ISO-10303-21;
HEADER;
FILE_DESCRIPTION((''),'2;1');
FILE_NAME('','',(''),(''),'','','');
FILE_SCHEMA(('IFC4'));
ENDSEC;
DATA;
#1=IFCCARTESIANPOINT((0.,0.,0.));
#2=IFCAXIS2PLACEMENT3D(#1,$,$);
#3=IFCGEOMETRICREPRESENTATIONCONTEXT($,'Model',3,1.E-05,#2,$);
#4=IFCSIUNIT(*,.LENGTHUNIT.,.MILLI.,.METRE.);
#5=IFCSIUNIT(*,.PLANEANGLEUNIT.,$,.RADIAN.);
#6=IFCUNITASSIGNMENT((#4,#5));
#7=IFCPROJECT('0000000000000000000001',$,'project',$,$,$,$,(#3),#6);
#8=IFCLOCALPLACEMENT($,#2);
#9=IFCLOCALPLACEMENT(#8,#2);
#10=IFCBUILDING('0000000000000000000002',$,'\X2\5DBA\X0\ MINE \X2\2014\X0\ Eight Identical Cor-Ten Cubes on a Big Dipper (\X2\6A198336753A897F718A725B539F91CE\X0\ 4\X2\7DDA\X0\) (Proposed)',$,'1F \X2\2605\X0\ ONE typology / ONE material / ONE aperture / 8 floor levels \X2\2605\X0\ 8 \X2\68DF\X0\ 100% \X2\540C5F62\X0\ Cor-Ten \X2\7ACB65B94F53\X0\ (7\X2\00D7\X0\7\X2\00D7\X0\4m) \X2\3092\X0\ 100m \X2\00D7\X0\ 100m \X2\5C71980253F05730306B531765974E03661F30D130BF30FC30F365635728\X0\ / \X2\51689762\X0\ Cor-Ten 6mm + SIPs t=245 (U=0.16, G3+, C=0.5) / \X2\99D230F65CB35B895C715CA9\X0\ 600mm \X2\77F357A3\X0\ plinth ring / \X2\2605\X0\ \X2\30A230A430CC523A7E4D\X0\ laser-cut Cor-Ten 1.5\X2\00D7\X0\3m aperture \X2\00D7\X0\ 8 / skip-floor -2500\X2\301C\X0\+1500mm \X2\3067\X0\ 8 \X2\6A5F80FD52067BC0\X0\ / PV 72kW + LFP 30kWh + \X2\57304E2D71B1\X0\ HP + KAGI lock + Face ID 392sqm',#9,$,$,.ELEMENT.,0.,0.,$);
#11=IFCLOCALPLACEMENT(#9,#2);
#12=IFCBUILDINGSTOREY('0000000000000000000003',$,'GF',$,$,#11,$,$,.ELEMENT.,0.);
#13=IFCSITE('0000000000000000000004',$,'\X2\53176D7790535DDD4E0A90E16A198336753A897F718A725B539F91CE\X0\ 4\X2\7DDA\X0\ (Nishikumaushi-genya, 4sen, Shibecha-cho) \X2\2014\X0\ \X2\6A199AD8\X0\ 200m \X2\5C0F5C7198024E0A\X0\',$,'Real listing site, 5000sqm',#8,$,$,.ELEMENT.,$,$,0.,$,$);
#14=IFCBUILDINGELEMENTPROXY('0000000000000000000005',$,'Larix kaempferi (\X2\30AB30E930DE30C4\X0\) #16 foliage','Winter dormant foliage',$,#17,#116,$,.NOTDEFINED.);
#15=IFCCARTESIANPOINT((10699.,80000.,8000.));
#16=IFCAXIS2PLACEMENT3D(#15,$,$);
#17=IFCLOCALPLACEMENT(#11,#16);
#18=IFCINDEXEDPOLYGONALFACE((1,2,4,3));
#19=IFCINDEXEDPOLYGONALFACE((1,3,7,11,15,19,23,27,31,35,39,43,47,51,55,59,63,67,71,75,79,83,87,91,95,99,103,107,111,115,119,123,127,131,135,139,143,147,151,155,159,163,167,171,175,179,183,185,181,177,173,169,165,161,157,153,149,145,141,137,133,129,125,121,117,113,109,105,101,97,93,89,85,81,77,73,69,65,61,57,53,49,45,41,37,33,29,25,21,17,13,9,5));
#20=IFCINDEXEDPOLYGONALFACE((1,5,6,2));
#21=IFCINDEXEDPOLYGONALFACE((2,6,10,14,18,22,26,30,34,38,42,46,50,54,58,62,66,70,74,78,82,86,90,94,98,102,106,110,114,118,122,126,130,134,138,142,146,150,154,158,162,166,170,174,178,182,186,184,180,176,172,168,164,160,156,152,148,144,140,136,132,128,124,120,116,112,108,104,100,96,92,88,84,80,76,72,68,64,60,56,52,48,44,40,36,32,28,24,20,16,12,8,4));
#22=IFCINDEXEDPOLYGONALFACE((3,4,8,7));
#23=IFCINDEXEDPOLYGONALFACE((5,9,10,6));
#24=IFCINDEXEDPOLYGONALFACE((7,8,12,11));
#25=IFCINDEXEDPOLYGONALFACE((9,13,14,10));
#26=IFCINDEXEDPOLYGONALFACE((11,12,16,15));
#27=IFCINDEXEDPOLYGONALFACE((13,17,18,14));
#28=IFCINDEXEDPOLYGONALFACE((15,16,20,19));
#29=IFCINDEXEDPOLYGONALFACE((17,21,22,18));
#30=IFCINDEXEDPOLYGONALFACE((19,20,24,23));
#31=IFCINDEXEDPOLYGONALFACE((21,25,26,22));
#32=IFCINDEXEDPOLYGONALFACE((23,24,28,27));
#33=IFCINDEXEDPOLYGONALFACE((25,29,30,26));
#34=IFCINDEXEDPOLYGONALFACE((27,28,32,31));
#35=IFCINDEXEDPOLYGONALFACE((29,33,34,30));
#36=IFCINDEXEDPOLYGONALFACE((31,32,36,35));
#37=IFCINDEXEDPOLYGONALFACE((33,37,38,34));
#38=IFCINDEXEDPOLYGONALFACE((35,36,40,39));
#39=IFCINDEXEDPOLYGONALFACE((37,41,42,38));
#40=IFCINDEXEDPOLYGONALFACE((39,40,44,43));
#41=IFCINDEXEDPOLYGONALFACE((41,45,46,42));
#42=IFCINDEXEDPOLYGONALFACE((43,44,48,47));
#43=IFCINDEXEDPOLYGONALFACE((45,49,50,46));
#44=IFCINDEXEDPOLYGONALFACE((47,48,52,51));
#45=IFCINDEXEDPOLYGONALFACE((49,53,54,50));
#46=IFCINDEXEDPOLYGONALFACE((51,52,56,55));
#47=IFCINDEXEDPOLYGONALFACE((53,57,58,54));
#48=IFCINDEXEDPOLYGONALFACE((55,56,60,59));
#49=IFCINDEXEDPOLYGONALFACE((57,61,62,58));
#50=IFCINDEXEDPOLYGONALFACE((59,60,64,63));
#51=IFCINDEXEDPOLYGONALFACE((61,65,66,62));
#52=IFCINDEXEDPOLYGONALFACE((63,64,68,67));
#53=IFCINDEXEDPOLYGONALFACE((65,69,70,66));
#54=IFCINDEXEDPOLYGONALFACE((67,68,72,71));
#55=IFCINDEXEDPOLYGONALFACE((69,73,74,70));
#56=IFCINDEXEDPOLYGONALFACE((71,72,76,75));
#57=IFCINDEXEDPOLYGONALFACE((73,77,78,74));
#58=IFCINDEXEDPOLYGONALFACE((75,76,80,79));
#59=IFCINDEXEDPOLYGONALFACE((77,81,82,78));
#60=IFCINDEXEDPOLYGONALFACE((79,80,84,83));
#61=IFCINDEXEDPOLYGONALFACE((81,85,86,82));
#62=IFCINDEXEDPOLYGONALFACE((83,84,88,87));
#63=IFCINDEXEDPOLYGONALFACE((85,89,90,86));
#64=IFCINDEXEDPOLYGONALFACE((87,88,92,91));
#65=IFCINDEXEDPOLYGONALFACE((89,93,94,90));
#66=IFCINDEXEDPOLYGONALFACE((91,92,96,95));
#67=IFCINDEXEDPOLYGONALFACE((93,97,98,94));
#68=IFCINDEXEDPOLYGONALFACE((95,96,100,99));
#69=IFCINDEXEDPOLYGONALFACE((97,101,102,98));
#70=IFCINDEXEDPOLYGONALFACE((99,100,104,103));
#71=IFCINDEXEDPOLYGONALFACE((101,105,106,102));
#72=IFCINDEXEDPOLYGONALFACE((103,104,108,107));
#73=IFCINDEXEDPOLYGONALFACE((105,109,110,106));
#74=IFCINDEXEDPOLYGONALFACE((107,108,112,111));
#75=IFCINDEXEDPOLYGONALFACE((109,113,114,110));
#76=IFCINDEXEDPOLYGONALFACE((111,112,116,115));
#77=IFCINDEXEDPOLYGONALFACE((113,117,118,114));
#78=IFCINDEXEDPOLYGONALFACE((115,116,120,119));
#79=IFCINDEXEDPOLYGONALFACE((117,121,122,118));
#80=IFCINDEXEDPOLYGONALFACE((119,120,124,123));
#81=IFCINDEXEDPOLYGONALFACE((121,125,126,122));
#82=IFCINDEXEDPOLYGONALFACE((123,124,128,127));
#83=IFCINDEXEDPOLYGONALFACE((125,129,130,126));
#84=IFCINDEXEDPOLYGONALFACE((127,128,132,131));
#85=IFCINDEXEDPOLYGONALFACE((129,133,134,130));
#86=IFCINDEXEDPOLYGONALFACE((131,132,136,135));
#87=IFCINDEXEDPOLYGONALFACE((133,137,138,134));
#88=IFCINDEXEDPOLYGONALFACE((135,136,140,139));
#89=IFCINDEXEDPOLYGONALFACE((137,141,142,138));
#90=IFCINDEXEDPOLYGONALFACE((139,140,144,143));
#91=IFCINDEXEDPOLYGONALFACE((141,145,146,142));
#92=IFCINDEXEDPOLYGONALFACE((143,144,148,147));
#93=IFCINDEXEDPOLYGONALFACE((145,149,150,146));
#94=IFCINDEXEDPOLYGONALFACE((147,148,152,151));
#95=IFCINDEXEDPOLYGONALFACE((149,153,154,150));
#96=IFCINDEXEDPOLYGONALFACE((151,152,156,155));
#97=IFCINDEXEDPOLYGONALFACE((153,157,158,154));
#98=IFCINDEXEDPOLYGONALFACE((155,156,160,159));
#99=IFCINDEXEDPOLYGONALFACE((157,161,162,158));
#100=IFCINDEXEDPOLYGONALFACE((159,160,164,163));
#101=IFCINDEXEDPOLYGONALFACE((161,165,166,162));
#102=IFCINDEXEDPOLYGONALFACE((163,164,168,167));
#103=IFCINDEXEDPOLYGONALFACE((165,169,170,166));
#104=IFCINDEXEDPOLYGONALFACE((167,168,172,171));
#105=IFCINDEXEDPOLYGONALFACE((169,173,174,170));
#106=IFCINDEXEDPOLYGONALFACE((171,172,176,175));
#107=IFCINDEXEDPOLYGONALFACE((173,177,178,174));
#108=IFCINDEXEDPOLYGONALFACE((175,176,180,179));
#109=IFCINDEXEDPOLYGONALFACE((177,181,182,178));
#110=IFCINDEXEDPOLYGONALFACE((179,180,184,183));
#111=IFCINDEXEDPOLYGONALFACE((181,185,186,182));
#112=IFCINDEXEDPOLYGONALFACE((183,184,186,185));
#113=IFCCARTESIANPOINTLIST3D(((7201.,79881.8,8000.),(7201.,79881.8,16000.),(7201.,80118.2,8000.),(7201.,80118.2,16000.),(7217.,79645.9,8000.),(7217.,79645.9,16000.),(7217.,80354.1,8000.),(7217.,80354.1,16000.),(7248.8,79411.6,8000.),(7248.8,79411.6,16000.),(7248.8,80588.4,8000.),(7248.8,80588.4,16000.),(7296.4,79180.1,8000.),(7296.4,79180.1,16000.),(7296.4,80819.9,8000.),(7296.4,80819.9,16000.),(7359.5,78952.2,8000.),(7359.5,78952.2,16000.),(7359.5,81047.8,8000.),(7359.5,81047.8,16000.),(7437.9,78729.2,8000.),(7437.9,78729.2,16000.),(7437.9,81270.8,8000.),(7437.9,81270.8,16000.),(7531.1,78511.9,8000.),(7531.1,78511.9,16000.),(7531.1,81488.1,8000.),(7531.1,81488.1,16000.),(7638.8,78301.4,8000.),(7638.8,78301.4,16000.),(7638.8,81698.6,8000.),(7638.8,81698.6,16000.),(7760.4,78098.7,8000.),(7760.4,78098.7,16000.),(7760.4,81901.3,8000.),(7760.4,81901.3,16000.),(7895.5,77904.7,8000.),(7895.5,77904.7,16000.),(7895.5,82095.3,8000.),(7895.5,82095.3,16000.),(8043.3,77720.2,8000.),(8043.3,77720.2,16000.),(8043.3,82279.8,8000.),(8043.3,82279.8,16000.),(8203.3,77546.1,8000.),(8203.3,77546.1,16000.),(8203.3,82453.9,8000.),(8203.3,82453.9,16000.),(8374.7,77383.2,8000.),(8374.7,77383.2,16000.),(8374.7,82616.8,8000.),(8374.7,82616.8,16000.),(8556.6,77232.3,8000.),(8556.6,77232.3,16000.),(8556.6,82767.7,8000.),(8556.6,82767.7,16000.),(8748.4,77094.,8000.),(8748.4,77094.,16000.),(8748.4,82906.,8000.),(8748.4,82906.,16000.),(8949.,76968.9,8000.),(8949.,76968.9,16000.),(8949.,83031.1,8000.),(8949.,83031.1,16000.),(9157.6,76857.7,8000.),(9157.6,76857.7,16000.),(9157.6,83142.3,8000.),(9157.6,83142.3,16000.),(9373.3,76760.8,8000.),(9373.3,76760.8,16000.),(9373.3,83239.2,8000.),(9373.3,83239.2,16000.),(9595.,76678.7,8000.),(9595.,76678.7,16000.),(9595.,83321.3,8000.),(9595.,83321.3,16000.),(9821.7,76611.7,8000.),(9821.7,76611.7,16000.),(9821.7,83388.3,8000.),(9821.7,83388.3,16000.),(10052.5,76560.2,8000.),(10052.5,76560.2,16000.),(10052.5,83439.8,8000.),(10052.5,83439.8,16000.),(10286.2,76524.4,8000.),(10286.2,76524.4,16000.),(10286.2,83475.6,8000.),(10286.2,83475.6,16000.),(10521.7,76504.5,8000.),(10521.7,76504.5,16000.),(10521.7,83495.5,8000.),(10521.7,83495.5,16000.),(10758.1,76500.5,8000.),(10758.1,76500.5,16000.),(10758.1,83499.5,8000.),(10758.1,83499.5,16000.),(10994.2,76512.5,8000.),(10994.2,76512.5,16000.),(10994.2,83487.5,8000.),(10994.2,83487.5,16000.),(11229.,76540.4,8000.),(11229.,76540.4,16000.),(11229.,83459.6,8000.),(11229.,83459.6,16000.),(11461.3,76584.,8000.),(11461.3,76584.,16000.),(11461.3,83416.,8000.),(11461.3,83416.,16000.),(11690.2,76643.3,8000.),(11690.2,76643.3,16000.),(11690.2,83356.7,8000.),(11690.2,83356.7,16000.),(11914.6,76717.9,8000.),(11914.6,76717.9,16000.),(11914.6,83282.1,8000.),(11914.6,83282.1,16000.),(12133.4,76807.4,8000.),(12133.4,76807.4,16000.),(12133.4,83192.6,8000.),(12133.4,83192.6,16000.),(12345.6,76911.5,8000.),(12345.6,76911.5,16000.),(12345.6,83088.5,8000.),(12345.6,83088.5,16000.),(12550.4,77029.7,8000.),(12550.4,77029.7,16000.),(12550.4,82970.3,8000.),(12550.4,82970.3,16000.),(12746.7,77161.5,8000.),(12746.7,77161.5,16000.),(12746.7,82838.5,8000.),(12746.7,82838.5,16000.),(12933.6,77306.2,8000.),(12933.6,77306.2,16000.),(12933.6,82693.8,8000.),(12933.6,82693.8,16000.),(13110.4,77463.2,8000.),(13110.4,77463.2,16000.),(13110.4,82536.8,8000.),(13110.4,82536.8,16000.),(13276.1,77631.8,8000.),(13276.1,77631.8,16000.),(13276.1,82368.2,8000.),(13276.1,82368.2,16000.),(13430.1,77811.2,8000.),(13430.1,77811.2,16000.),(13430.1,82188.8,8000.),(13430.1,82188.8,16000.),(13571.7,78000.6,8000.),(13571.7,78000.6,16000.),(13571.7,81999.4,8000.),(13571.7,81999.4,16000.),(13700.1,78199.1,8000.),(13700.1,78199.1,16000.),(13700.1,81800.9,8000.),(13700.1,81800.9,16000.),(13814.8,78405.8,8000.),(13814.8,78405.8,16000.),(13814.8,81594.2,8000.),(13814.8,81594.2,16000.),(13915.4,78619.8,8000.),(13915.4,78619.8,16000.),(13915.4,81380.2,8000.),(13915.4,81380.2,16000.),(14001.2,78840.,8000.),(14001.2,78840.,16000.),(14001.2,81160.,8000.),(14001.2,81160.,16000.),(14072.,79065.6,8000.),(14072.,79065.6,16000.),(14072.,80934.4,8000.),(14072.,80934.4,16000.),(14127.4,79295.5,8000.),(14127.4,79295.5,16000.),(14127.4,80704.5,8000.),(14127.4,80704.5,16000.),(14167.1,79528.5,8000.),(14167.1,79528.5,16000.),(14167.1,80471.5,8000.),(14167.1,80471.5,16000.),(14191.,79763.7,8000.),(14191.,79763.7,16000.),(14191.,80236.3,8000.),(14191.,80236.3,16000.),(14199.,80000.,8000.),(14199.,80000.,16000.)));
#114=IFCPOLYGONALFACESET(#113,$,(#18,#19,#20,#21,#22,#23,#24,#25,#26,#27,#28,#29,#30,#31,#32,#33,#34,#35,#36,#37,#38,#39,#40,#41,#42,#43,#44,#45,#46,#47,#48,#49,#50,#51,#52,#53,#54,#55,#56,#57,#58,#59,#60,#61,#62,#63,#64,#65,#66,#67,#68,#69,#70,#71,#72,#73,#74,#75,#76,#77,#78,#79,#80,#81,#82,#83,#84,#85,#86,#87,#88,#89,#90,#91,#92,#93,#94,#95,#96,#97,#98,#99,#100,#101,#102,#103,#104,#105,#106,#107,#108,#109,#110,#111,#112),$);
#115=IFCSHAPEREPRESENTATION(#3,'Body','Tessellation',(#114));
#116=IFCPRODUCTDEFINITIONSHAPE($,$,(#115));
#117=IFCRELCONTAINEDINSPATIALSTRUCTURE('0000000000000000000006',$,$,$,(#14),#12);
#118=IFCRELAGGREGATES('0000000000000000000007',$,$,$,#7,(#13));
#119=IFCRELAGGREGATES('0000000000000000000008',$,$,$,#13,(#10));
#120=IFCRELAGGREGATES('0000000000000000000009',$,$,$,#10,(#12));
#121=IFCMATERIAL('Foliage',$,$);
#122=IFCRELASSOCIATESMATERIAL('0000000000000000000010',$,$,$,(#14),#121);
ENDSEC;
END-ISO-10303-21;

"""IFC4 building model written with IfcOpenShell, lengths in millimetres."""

from ifc_helpers import new_model, si_unit, frame, origin, origin_2d, place, context, project, spatial, circle, extrude, material, element, save


model = new_model("IFC4")

# Units and contexts
model_context = context("Model", 3, precision=1e-05, world=origin())
ifc_project = project(units=[si_unit("LENGTHUNIT", "METRE", prefix="MILLI"), si_unit("PLANEANGLEUNIT", "RADIAN")], contexts=[model_context])

# Site, building, storey
site_placement = place(None, origin())
site = spatial("IfcSite", under=ifc_project, at=site_placement, Name="北海道川上郡標茶町西熊牛原野 4線 (Nishikumaushi-genya, 4sen, Shibecha-cho) — 標高 200m 小山頂上", ObjectType="Real listing site, 5000sqm", CompositionType="ELEMENT", RefElevation=0.0)
building_placement = place(site_placement, origin())
building = spatial("IfcBuilding", under=site, at=building_placement, Name="嶺 MINE — Eight Identical Cor-Ten Cubes on a Big Dipper (標茶町西熊牛原野 4線) (Proposed)", ObjectType="1F ★ ONE typology / ONE material / ONE aperture / 8 floor levels ★ 8 棟 100% 同形 Cor-Ten 立方体 (7×7×4m) を 100m × 100m 山頂台地に北斗七星パターン散在 / 全面 Cor-Ten 6mm + SIPs t=245 (U=0.16, G3+, C=0.5) / 駒ヶ岳安山岩 600mm 石垣 plinth ring / ★ アイヌ刺繍 laser-cut Cor-Ten 1.5×3m aperture × 8 / skip-floor -2500〜+1500mm で 8 機能分節 / PV 72kW + LFP 30kWh + 地中熱 HP + KAGI lock + Face ID 392sqm", CompositionType="ELEMENT", ElevationOfRefHeight=0.0, ElevationOfTerrain=0.0)
storey_placement = place(building_placement, origin())
storey = spatial("IfcBuildingStorey", under=building, at=storey_placement, Name="GF", CompositionType="ELEMENT", Elevation=0.0)

# Building element proxy
ifc_material_1 = material(Name="Foliage")
proxy_1_placement = place(storey_placement, frame((10699.0, 80000.0, 8000.0)))
element("IfcBuildingElementProxy", 1, at=proxy_1_placement, inside=storey, material=ifc_material_1, Name="Larix kaempferi (カラマツ) #16 foliage", Description="Winter dormant foliage", PredefinedType="NOTDEFINED", context=model_context, shape_type="SweptSolid", body=[
    extrude(circle(Radius=3500.0, at=origin_2d()), frame((10699.0, 80000.0, 8000.0)), (0.0, 0.0, 1.0), 8000.0),
])

save(model, "model.ifc")
